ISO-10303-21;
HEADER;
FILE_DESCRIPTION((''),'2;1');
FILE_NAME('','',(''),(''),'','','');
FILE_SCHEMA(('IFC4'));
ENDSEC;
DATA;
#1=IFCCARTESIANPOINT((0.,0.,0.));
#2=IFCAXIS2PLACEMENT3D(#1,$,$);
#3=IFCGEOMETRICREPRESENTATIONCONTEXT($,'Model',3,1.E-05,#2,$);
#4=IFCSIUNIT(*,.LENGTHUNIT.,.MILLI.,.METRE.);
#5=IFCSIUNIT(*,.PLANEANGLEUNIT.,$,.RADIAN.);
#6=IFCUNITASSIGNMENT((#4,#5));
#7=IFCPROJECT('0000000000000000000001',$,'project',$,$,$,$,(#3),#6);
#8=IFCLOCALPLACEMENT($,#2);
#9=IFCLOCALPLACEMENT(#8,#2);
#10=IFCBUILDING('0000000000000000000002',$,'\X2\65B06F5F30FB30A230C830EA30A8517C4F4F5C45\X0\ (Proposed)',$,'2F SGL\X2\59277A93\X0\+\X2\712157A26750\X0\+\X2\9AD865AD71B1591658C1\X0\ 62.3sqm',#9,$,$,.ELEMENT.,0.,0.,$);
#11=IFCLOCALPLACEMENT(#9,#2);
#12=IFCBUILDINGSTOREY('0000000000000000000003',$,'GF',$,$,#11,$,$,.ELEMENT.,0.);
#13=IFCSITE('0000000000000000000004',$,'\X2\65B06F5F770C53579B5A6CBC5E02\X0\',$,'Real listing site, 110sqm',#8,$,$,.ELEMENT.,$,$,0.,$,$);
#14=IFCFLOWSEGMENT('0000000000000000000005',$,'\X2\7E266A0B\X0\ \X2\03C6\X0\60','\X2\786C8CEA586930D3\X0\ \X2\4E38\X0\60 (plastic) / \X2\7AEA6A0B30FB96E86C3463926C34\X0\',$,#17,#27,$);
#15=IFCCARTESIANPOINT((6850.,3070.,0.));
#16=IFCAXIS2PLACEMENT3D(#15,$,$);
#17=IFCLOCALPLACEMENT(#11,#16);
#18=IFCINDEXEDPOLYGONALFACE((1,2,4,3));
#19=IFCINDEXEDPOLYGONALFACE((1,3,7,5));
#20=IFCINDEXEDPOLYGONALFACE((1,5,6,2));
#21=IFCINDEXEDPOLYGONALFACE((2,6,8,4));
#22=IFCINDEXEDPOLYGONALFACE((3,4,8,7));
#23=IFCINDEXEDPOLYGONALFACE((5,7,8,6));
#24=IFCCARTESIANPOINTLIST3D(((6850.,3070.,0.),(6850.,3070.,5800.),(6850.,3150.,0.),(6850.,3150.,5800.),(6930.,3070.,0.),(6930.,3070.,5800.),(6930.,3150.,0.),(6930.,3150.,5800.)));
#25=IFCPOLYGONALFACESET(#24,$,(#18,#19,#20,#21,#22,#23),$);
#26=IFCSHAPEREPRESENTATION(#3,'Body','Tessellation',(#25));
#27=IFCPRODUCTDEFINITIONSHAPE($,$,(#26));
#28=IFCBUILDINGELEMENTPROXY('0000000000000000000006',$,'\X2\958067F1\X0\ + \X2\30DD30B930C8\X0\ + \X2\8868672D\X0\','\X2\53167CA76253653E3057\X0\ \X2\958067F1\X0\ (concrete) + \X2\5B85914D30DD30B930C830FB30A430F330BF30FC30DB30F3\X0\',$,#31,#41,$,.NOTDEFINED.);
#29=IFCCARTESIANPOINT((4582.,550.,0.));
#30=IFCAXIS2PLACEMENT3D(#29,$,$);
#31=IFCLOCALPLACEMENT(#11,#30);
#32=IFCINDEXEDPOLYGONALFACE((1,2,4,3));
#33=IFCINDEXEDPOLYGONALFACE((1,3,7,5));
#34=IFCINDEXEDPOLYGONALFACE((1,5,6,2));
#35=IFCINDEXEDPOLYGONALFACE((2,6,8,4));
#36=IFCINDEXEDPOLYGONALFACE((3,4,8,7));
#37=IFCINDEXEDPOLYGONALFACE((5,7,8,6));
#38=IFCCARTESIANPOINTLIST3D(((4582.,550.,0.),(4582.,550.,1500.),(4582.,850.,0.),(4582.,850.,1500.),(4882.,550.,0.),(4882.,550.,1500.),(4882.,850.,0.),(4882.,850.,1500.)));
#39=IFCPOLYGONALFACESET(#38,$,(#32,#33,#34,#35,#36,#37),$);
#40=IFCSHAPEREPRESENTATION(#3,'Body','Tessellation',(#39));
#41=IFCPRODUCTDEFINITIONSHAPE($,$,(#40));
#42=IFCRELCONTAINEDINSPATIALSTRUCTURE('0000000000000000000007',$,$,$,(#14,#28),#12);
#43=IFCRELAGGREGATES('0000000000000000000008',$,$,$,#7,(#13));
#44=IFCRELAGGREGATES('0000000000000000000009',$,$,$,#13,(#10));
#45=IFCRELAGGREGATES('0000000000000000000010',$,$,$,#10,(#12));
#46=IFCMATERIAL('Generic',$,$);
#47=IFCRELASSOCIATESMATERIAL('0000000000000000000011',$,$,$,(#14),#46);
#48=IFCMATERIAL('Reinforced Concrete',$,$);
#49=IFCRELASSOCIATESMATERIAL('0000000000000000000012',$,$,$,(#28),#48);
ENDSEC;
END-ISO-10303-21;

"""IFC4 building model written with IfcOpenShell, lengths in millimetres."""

from ifc_helpers import new_model, si_unit, frame, frame_2d, origin, place, context, project, spatial, rectangle, extrude, material, element, save


model = new_model("IFC4")

# Units and contexts
model_context = context("Model", 3, precision=1e-05, world=origin())
ifc_project = project(units=[si_unit("LENGTHUNIT", "METRE", prefix="MILLI"), si_unit("PLANEANGLEUNIT", "RADIAN")], contexts=[model_context])

# Site, building, storey
site_placement = place(None, origin())
site = spatial("IfcSite", under=ifc_project, at=site_placement, Name="新潟県南魚沼市", ObjectType="Real listing site, 110sqm", CompositionType="ELEMENT", RefElevation=0.0)
building_placement = place(site_placement, origin())
building = spatial("IfcBuilding", under=site, at=building_placement, Name="新潟・アトリエ兼住居 (Proposed)", ObjectType="2F SGL大窓+無垢材+高断熱外壁 62.3sqm", CompositionType="ELEMENT", ElevationOfRefHeight=0.0, ElevationOfTerrain=0.0)
storey_placement = place(building_placement, origin())
storey = spatial("IfcBuildingStorey", under=building, at=storey_placement, Name="GF", CompositionType="ELEMENT", Elevation=0.0)

# Shared definitions
ifc_material_1 = material(Name="Generic")
ifc_material_2 = material(Name="Reinforced Concrete")

# Flow segment
flow_segment_placement = place(storey_placement, frame((6850.0, 3070.0, 0.0)))
element("IfcFlowSegment", 1, at=flow_segment_placement, inside=storey, material=ifc_material_1, Name="縦樋 φ60", Description="硬質塩ビ 丸60 (plastic) / 竪樋・雨水排水", context=model_context, shape_type="SweptSolid", body=[
    extrude(rectangle(XDim=80.0, YDim=80.0, at=frame_2d((40.0, 40.0))), frame((6850.0, 3070.0, 0.0)), (0.0, 0.0, 1.0), 5800.0),
])

# Building element proxy
proxy_placement = place(storey_placement, frame((4582.0, 550.0, 0.0)))
element("IfcBuildingElementProxy", 2, at=proxy_placement, inside=storey, material=ifc_material_2, Name="門柱 + ポスト + 表札", Description="化粧打放し 門柱 (concrete) + 宅配ポスト・インターホン", PredefinedType="NOTDEFINED", context=model_context, shape_type="SweptSolid", body=[
    extrude(rectangle(XDim=300.0, YDim=300.0, at=frame_2d((150.0, 150.0))), frame((4582.0, 550.0, 0.0)), (0.0, 0.0, 1.0), 1500.0),
])

save(model, "model.ifc")
